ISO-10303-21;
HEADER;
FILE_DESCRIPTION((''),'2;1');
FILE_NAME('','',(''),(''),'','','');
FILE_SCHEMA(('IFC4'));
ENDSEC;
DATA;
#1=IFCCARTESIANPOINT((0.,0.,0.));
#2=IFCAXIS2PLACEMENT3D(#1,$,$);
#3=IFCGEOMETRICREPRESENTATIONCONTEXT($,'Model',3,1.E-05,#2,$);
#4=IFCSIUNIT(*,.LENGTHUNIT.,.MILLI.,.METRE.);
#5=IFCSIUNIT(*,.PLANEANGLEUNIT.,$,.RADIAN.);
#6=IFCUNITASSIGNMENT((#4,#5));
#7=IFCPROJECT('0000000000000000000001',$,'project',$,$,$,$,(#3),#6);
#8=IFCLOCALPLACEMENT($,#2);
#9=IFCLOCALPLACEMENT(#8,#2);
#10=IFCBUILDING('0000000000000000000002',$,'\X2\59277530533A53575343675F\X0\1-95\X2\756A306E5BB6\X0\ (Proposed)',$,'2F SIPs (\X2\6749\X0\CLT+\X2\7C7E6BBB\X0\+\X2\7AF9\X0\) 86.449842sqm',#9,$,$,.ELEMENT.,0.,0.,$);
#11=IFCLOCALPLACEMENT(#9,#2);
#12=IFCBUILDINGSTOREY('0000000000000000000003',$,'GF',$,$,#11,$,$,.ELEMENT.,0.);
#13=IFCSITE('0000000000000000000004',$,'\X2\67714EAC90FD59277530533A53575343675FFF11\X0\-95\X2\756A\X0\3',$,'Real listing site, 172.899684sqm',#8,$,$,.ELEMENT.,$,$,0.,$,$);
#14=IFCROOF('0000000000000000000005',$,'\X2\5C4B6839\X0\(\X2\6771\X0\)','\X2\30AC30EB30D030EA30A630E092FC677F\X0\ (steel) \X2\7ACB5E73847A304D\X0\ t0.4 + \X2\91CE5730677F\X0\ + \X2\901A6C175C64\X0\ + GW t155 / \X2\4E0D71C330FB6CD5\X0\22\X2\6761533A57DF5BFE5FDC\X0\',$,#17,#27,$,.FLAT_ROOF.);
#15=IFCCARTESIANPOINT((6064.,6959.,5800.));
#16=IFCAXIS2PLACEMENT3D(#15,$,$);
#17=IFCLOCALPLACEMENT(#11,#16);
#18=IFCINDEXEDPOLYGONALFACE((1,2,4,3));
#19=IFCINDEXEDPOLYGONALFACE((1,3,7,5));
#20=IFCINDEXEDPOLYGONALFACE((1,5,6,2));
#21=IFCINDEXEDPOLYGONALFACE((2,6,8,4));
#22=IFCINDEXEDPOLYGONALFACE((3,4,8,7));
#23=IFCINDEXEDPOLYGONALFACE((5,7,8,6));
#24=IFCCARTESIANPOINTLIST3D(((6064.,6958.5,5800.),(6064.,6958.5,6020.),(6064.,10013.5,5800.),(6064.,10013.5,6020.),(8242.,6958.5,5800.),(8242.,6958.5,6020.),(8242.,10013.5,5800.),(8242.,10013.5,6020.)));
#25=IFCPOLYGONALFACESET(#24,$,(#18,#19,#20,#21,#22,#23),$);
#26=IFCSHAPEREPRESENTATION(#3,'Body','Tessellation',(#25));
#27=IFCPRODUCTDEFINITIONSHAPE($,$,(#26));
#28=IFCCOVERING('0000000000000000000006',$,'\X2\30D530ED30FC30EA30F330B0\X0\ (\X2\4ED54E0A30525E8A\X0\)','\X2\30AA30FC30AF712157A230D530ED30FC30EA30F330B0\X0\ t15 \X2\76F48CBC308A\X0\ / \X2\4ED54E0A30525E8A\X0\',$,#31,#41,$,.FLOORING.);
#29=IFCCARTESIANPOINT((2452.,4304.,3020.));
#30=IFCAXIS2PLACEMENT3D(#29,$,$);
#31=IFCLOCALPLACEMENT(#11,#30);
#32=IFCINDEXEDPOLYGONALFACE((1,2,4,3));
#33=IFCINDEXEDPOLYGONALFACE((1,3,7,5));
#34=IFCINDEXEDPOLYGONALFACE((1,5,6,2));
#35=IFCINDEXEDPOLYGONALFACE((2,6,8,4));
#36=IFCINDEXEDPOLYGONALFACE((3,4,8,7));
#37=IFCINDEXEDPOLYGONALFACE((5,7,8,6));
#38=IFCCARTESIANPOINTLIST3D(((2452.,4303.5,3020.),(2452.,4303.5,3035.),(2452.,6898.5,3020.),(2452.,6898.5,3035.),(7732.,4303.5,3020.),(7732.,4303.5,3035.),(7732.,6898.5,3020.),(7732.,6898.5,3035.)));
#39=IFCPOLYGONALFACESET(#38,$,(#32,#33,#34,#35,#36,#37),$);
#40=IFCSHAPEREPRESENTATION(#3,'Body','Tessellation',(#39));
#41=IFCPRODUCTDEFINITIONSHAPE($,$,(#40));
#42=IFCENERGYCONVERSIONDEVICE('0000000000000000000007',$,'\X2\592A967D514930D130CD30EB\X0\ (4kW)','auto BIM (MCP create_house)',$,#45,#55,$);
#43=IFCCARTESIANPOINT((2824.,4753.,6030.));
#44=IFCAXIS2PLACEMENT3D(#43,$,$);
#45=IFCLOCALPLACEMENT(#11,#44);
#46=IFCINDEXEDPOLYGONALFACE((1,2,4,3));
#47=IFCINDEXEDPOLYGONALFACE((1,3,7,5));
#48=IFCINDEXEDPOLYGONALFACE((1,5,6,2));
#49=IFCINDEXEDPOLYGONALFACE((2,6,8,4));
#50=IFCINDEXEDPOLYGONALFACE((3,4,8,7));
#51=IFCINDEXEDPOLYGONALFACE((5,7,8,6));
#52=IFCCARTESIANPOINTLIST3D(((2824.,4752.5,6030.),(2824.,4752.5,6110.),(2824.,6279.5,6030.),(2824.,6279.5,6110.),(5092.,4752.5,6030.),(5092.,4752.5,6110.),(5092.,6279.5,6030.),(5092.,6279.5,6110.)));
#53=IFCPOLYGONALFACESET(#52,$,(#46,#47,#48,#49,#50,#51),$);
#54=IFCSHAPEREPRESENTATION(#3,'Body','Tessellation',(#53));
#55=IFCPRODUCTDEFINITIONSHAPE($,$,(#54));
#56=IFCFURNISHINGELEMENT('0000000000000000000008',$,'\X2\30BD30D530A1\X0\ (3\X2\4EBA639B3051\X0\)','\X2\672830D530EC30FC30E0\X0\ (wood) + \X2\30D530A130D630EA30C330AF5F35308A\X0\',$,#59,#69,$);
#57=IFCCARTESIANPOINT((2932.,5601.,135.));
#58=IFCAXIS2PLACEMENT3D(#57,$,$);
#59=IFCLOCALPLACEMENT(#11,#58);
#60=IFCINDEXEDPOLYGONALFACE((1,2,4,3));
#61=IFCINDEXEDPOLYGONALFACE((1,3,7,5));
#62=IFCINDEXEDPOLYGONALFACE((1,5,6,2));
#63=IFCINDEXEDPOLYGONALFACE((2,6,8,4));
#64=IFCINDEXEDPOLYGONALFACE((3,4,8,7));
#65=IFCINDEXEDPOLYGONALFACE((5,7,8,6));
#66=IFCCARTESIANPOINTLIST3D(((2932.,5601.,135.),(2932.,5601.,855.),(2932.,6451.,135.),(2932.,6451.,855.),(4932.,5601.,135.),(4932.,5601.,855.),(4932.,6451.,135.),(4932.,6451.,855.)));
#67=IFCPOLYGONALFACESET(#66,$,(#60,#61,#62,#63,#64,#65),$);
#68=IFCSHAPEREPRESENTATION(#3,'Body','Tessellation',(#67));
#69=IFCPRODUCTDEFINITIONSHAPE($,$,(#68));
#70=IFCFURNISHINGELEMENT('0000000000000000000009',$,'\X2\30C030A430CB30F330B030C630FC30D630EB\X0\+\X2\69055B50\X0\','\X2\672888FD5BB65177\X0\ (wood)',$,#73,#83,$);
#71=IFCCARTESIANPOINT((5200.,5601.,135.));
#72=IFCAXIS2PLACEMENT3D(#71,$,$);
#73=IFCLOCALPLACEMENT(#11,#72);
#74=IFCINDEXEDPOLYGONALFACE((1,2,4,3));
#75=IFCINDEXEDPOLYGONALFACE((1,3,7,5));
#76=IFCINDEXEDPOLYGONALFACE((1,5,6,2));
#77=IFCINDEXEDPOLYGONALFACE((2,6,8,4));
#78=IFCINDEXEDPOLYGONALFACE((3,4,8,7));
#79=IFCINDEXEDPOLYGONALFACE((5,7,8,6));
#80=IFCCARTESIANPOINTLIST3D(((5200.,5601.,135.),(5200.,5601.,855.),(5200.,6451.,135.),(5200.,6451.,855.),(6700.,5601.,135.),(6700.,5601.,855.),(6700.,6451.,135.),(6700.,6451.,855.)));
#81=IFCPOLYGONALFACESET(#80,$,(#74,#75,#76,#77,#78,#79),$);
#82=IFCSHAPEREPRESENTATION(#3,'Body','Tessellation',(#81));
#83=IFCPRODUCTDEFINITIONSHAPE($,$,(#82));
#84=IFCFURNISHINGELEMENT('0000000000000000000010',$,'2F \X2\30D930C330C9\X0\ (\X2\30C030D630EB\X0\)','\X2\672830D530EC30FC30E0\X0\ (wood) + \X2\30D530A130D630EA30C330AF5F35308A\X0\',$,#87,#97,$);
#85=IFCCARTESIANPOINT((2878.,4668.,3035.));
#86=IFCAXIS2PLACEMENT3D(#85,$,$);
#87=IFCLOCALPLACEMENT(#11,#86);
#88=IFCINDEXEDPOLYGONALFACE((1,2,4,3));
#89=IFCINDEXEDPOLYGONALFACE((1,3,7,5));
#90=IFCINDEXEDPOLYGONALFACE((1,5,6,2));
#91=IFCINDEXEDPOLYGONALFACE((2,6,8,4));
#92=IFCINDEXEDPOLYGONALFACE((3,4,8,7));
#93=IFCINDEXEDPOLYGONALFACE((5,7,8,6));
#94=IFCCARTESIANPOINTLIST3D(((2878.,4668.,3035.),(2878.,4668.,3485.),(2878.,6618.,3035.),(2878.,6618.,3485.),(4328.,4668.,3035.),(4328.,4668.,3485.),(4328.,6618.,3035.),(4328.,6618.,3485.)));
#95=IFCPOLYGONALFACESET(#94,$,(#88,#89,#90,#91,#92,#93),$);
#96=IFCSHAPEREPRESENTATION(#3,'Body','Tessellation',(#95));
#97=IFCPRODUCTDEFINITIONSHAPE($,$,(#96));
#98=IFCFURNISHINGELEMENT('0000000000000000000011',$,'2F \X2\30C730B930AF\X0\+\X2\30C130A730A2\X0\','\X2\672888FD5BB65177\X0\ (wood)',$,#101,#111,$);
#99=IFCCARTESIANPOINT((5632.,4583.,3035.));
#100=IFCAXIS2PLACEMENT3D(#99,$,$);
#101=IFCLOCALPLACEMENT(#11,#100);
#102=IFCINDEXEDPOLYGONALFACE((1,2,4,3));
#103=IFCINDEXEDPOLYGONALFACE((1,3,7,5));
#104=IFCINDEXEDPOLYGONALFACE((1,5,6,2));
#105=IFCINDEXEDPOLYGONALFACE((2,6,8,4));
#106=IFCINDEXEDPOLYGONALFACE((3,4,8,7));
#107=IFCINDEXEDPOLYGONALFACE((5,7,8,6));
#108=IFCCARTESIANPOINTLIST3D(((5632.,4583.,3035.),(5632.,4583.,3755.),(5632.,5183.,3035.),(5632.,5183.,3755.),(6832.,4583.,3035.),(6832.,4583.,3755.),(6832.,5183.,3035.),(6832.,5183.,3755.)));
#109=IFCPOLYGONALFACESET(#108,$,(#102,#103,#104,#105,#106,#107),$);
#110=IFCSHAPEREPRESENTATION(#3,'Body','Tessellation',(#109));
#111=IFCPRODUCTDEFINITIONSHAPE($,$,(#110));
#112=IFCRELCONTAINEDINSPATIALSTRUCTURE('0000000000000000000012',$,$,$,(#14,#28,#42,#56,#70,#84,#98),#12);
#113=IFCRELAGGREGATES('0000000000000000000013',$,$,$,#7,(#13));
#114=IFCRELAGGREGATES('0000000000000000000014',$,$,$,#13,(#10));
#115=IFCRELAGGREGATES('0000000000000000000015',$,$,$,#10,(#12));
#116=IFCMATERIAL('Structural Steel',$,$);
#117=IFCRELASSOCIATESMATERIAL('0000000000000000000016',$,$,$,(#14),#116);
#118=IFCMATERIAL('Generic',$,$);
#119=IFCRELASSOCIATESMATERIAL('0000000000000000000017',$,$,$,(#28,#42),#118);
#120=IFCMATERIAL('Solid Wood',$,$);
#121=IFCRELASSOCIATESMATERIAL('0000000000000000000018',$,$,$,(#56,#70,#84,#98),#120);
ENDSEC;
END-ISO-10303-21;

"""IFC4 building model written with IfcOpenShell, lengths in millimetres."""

from ifc_helpers import new_model, si_unit, frame, frame_2d, origin, place, context, project, spatial, rectangle, extrude, material, element, save


model = new_model("IFC4")

# Units and contexts
model_context = context("Model", 3, precision=1e-05, world=origin())
ifc_project = project(units=[si_unit("LENGTHUNIT", "METRE", prefix="MILLI"), si_unit("PLANEANGLEUNIT", "RADIAN")], contexts=[model_context])

# Site, building, storey
site_placement = place(None, origin())
site = spatial("IfcSite", under=ifc_project, at=site_placement, Name="東京都大田区南千束１-95番3", ObjectType="Real listing site, 172.899684sqm", CompositionType="ELEMENT", RefElevation=0.0)
building_placement = place(site_placement, origin())
building = spatial("IfcBuilding", under=site, at=building_placement, Name="大田区南千束1-95番の家 (Proposed)", ObjectType="2F SIPs (杉CLT+籾殻+竹) 86.449842sqm", CompositionType="ELEMENT", ElevationOfRefHeight=0.0, ElevationOfTerrain=0.0)
storey_placement = place(building_placement, origin())
storey = spatial("IfcBuildingStorey", under=building, at=storey_placement, Name="GF", CompositionType="ELEMENT", Elevation=0.0)

# Shared definitions
ifc_material_1 = material(Name="Solid Wood")

# Roof
ifc_material_2 = material(Name="Structural Steel")
roof_1_placement = place(storey_placement, frame((6064.0, 6959.0, 5800.0)))
element("IfcRoof", 1, at=roof_1_placement, inside=storey, material=ifc_material_2, Name="屋根(東)", Description="ガルバリウム鋼板 (steel) 立平葺き t0.4 + 野地板 + 通気層 + GW t155 / 不燃・法22条区域対応", PredefinedType="FLAT_ROOF", context=model_context, shape_type="SweptSolid", body=[
    extrude(rectangle(XDim=2178.0, YDim=3055.0, at=frame_2d((1089.0, 1527.0))), frame((6064.0, 6959.0, 5800.0)), (0.0, 0.0, 1.0), 220.0),
])

# Covering
ifc_material_3 = material(Name="Generic")
covering_placement = place(storey_placement, frame((2452.0, 4304.0, 3020.0)))
element("IfcCovering", 2, at=covering_placement, inside=storey, material=ifc_material_3, Name="フローリング (仕上げ床)", Description="オーク無垢フローリング t15 直貼り / 仕上げ床", PredefinedType="FLOORING", context=model_context, shape_type="SweptSolid", body=[
    extrude(rectangle(XDim=5280.0, YDim=2595.0, at=frame_2d((2640.0, 1297.0))), frame((2452.0, 4304.0, 3020.0)), (0.0, 0.0, 1.0), 15.0),
])

# Energy conversion device
energy_conversion_device_placement = place(storey_placement, frame((2824.0, 4753.0, 6030.0)))
element("IfcEnergyConversionDevice", 3, at=energy_conversion_device_placement, inside=storey, material=ifc_material_3, Name="太陽光パネル (4kW)", Description="auto BIM (MCP create_house)", context=model_context, shape_type="SweptSolid", body=[
    extrude(rectangle(XDim=2268.0, YDim=1527.0, at=frame_2d((1134.0, 763.0))), frame((2824.0, 4753.0, 6030.0)), (0.0, 0.0, 1.0), 80.0),
])

# Furnishing elements
furnishing_1_placement = place(storey_placement, frame((2932.0, 5601.0, 135.0)))
element("IfcFurnishingElement", 4, at=furnishing_1_placement, inside=storey, material=ifc_material_1, Name="ソファ (3人掛け)", Description="木フレーム (wood) + ファブリック張り", context=model_context, shape_type="SweptSolid", body=[
    extrude(rectangle(XDim=2000.0, YDim=850.0, at=frame_2d((1000.0, 425.0))), frame((2932.0, 5601.0, 135.0)), (0.0, 0.0, 1.0), 720.0),
])
furnishing_2_placement = place(storey_placement, frame((5200.0, 5601.0, 135.0)))
element("IfcFurnishingElement", 5, at=furnishing_2_placement, inside=storey, material=ifc_material_1, Name="ダイニングテーブル+椅子", Description="木製家具 (wood)", context=model_context, shape_type="SweptSolid", body=[
    extrude(rectangle(XDim=1500.0, YDim=850.0, at=frame_2d((750.0, 425.0))), frame((5200.0, 5601.0, 135.0)), (0.0, 0.0, 1.0), 720.0),
])
furnishing_3_placement = place(storey_placement, frame((2878.0, 4668.0, 3035.0)))
element("IfcFurnishingElement", 6, at=furnishing_3_placement, inside=storey, material=ifc_material_1, Name="2F ベッド (ダブル)", Description="木フレーム (wood) + ファブリック張り", context=model_context, shape_type="SweptSolid", body=[
    extrude(rectangle(XDim=1450.0, YDim=1950.0, at=frame_2d((725.0, 975.0))), frame((2878.0, 4668.0, 3035.0)), (0.0, 0.0, 1.0), 450.0),
])
furnishing_4_placement = place(storey_placement, frame((5632.0, 4583.0, 3035.0)))
element("IfcFurnishingElement", 7, at=furnishing_4_placement, inside=storey, material=ifc_material_1, Name="2F デスク+チェア", Description="木製家具 (wood)", context=model_context, shape_type="SweptSolid", body=[
    extrude(rectangle(XDim=1200.0, YDim=600.0, at=frame_2d((600.0, 300.0))), frame((5632.0, 4583.0, 3035.0)), (0.0, 0.0, 1.0), 720.0),
])

save(model, "model.ifc")
